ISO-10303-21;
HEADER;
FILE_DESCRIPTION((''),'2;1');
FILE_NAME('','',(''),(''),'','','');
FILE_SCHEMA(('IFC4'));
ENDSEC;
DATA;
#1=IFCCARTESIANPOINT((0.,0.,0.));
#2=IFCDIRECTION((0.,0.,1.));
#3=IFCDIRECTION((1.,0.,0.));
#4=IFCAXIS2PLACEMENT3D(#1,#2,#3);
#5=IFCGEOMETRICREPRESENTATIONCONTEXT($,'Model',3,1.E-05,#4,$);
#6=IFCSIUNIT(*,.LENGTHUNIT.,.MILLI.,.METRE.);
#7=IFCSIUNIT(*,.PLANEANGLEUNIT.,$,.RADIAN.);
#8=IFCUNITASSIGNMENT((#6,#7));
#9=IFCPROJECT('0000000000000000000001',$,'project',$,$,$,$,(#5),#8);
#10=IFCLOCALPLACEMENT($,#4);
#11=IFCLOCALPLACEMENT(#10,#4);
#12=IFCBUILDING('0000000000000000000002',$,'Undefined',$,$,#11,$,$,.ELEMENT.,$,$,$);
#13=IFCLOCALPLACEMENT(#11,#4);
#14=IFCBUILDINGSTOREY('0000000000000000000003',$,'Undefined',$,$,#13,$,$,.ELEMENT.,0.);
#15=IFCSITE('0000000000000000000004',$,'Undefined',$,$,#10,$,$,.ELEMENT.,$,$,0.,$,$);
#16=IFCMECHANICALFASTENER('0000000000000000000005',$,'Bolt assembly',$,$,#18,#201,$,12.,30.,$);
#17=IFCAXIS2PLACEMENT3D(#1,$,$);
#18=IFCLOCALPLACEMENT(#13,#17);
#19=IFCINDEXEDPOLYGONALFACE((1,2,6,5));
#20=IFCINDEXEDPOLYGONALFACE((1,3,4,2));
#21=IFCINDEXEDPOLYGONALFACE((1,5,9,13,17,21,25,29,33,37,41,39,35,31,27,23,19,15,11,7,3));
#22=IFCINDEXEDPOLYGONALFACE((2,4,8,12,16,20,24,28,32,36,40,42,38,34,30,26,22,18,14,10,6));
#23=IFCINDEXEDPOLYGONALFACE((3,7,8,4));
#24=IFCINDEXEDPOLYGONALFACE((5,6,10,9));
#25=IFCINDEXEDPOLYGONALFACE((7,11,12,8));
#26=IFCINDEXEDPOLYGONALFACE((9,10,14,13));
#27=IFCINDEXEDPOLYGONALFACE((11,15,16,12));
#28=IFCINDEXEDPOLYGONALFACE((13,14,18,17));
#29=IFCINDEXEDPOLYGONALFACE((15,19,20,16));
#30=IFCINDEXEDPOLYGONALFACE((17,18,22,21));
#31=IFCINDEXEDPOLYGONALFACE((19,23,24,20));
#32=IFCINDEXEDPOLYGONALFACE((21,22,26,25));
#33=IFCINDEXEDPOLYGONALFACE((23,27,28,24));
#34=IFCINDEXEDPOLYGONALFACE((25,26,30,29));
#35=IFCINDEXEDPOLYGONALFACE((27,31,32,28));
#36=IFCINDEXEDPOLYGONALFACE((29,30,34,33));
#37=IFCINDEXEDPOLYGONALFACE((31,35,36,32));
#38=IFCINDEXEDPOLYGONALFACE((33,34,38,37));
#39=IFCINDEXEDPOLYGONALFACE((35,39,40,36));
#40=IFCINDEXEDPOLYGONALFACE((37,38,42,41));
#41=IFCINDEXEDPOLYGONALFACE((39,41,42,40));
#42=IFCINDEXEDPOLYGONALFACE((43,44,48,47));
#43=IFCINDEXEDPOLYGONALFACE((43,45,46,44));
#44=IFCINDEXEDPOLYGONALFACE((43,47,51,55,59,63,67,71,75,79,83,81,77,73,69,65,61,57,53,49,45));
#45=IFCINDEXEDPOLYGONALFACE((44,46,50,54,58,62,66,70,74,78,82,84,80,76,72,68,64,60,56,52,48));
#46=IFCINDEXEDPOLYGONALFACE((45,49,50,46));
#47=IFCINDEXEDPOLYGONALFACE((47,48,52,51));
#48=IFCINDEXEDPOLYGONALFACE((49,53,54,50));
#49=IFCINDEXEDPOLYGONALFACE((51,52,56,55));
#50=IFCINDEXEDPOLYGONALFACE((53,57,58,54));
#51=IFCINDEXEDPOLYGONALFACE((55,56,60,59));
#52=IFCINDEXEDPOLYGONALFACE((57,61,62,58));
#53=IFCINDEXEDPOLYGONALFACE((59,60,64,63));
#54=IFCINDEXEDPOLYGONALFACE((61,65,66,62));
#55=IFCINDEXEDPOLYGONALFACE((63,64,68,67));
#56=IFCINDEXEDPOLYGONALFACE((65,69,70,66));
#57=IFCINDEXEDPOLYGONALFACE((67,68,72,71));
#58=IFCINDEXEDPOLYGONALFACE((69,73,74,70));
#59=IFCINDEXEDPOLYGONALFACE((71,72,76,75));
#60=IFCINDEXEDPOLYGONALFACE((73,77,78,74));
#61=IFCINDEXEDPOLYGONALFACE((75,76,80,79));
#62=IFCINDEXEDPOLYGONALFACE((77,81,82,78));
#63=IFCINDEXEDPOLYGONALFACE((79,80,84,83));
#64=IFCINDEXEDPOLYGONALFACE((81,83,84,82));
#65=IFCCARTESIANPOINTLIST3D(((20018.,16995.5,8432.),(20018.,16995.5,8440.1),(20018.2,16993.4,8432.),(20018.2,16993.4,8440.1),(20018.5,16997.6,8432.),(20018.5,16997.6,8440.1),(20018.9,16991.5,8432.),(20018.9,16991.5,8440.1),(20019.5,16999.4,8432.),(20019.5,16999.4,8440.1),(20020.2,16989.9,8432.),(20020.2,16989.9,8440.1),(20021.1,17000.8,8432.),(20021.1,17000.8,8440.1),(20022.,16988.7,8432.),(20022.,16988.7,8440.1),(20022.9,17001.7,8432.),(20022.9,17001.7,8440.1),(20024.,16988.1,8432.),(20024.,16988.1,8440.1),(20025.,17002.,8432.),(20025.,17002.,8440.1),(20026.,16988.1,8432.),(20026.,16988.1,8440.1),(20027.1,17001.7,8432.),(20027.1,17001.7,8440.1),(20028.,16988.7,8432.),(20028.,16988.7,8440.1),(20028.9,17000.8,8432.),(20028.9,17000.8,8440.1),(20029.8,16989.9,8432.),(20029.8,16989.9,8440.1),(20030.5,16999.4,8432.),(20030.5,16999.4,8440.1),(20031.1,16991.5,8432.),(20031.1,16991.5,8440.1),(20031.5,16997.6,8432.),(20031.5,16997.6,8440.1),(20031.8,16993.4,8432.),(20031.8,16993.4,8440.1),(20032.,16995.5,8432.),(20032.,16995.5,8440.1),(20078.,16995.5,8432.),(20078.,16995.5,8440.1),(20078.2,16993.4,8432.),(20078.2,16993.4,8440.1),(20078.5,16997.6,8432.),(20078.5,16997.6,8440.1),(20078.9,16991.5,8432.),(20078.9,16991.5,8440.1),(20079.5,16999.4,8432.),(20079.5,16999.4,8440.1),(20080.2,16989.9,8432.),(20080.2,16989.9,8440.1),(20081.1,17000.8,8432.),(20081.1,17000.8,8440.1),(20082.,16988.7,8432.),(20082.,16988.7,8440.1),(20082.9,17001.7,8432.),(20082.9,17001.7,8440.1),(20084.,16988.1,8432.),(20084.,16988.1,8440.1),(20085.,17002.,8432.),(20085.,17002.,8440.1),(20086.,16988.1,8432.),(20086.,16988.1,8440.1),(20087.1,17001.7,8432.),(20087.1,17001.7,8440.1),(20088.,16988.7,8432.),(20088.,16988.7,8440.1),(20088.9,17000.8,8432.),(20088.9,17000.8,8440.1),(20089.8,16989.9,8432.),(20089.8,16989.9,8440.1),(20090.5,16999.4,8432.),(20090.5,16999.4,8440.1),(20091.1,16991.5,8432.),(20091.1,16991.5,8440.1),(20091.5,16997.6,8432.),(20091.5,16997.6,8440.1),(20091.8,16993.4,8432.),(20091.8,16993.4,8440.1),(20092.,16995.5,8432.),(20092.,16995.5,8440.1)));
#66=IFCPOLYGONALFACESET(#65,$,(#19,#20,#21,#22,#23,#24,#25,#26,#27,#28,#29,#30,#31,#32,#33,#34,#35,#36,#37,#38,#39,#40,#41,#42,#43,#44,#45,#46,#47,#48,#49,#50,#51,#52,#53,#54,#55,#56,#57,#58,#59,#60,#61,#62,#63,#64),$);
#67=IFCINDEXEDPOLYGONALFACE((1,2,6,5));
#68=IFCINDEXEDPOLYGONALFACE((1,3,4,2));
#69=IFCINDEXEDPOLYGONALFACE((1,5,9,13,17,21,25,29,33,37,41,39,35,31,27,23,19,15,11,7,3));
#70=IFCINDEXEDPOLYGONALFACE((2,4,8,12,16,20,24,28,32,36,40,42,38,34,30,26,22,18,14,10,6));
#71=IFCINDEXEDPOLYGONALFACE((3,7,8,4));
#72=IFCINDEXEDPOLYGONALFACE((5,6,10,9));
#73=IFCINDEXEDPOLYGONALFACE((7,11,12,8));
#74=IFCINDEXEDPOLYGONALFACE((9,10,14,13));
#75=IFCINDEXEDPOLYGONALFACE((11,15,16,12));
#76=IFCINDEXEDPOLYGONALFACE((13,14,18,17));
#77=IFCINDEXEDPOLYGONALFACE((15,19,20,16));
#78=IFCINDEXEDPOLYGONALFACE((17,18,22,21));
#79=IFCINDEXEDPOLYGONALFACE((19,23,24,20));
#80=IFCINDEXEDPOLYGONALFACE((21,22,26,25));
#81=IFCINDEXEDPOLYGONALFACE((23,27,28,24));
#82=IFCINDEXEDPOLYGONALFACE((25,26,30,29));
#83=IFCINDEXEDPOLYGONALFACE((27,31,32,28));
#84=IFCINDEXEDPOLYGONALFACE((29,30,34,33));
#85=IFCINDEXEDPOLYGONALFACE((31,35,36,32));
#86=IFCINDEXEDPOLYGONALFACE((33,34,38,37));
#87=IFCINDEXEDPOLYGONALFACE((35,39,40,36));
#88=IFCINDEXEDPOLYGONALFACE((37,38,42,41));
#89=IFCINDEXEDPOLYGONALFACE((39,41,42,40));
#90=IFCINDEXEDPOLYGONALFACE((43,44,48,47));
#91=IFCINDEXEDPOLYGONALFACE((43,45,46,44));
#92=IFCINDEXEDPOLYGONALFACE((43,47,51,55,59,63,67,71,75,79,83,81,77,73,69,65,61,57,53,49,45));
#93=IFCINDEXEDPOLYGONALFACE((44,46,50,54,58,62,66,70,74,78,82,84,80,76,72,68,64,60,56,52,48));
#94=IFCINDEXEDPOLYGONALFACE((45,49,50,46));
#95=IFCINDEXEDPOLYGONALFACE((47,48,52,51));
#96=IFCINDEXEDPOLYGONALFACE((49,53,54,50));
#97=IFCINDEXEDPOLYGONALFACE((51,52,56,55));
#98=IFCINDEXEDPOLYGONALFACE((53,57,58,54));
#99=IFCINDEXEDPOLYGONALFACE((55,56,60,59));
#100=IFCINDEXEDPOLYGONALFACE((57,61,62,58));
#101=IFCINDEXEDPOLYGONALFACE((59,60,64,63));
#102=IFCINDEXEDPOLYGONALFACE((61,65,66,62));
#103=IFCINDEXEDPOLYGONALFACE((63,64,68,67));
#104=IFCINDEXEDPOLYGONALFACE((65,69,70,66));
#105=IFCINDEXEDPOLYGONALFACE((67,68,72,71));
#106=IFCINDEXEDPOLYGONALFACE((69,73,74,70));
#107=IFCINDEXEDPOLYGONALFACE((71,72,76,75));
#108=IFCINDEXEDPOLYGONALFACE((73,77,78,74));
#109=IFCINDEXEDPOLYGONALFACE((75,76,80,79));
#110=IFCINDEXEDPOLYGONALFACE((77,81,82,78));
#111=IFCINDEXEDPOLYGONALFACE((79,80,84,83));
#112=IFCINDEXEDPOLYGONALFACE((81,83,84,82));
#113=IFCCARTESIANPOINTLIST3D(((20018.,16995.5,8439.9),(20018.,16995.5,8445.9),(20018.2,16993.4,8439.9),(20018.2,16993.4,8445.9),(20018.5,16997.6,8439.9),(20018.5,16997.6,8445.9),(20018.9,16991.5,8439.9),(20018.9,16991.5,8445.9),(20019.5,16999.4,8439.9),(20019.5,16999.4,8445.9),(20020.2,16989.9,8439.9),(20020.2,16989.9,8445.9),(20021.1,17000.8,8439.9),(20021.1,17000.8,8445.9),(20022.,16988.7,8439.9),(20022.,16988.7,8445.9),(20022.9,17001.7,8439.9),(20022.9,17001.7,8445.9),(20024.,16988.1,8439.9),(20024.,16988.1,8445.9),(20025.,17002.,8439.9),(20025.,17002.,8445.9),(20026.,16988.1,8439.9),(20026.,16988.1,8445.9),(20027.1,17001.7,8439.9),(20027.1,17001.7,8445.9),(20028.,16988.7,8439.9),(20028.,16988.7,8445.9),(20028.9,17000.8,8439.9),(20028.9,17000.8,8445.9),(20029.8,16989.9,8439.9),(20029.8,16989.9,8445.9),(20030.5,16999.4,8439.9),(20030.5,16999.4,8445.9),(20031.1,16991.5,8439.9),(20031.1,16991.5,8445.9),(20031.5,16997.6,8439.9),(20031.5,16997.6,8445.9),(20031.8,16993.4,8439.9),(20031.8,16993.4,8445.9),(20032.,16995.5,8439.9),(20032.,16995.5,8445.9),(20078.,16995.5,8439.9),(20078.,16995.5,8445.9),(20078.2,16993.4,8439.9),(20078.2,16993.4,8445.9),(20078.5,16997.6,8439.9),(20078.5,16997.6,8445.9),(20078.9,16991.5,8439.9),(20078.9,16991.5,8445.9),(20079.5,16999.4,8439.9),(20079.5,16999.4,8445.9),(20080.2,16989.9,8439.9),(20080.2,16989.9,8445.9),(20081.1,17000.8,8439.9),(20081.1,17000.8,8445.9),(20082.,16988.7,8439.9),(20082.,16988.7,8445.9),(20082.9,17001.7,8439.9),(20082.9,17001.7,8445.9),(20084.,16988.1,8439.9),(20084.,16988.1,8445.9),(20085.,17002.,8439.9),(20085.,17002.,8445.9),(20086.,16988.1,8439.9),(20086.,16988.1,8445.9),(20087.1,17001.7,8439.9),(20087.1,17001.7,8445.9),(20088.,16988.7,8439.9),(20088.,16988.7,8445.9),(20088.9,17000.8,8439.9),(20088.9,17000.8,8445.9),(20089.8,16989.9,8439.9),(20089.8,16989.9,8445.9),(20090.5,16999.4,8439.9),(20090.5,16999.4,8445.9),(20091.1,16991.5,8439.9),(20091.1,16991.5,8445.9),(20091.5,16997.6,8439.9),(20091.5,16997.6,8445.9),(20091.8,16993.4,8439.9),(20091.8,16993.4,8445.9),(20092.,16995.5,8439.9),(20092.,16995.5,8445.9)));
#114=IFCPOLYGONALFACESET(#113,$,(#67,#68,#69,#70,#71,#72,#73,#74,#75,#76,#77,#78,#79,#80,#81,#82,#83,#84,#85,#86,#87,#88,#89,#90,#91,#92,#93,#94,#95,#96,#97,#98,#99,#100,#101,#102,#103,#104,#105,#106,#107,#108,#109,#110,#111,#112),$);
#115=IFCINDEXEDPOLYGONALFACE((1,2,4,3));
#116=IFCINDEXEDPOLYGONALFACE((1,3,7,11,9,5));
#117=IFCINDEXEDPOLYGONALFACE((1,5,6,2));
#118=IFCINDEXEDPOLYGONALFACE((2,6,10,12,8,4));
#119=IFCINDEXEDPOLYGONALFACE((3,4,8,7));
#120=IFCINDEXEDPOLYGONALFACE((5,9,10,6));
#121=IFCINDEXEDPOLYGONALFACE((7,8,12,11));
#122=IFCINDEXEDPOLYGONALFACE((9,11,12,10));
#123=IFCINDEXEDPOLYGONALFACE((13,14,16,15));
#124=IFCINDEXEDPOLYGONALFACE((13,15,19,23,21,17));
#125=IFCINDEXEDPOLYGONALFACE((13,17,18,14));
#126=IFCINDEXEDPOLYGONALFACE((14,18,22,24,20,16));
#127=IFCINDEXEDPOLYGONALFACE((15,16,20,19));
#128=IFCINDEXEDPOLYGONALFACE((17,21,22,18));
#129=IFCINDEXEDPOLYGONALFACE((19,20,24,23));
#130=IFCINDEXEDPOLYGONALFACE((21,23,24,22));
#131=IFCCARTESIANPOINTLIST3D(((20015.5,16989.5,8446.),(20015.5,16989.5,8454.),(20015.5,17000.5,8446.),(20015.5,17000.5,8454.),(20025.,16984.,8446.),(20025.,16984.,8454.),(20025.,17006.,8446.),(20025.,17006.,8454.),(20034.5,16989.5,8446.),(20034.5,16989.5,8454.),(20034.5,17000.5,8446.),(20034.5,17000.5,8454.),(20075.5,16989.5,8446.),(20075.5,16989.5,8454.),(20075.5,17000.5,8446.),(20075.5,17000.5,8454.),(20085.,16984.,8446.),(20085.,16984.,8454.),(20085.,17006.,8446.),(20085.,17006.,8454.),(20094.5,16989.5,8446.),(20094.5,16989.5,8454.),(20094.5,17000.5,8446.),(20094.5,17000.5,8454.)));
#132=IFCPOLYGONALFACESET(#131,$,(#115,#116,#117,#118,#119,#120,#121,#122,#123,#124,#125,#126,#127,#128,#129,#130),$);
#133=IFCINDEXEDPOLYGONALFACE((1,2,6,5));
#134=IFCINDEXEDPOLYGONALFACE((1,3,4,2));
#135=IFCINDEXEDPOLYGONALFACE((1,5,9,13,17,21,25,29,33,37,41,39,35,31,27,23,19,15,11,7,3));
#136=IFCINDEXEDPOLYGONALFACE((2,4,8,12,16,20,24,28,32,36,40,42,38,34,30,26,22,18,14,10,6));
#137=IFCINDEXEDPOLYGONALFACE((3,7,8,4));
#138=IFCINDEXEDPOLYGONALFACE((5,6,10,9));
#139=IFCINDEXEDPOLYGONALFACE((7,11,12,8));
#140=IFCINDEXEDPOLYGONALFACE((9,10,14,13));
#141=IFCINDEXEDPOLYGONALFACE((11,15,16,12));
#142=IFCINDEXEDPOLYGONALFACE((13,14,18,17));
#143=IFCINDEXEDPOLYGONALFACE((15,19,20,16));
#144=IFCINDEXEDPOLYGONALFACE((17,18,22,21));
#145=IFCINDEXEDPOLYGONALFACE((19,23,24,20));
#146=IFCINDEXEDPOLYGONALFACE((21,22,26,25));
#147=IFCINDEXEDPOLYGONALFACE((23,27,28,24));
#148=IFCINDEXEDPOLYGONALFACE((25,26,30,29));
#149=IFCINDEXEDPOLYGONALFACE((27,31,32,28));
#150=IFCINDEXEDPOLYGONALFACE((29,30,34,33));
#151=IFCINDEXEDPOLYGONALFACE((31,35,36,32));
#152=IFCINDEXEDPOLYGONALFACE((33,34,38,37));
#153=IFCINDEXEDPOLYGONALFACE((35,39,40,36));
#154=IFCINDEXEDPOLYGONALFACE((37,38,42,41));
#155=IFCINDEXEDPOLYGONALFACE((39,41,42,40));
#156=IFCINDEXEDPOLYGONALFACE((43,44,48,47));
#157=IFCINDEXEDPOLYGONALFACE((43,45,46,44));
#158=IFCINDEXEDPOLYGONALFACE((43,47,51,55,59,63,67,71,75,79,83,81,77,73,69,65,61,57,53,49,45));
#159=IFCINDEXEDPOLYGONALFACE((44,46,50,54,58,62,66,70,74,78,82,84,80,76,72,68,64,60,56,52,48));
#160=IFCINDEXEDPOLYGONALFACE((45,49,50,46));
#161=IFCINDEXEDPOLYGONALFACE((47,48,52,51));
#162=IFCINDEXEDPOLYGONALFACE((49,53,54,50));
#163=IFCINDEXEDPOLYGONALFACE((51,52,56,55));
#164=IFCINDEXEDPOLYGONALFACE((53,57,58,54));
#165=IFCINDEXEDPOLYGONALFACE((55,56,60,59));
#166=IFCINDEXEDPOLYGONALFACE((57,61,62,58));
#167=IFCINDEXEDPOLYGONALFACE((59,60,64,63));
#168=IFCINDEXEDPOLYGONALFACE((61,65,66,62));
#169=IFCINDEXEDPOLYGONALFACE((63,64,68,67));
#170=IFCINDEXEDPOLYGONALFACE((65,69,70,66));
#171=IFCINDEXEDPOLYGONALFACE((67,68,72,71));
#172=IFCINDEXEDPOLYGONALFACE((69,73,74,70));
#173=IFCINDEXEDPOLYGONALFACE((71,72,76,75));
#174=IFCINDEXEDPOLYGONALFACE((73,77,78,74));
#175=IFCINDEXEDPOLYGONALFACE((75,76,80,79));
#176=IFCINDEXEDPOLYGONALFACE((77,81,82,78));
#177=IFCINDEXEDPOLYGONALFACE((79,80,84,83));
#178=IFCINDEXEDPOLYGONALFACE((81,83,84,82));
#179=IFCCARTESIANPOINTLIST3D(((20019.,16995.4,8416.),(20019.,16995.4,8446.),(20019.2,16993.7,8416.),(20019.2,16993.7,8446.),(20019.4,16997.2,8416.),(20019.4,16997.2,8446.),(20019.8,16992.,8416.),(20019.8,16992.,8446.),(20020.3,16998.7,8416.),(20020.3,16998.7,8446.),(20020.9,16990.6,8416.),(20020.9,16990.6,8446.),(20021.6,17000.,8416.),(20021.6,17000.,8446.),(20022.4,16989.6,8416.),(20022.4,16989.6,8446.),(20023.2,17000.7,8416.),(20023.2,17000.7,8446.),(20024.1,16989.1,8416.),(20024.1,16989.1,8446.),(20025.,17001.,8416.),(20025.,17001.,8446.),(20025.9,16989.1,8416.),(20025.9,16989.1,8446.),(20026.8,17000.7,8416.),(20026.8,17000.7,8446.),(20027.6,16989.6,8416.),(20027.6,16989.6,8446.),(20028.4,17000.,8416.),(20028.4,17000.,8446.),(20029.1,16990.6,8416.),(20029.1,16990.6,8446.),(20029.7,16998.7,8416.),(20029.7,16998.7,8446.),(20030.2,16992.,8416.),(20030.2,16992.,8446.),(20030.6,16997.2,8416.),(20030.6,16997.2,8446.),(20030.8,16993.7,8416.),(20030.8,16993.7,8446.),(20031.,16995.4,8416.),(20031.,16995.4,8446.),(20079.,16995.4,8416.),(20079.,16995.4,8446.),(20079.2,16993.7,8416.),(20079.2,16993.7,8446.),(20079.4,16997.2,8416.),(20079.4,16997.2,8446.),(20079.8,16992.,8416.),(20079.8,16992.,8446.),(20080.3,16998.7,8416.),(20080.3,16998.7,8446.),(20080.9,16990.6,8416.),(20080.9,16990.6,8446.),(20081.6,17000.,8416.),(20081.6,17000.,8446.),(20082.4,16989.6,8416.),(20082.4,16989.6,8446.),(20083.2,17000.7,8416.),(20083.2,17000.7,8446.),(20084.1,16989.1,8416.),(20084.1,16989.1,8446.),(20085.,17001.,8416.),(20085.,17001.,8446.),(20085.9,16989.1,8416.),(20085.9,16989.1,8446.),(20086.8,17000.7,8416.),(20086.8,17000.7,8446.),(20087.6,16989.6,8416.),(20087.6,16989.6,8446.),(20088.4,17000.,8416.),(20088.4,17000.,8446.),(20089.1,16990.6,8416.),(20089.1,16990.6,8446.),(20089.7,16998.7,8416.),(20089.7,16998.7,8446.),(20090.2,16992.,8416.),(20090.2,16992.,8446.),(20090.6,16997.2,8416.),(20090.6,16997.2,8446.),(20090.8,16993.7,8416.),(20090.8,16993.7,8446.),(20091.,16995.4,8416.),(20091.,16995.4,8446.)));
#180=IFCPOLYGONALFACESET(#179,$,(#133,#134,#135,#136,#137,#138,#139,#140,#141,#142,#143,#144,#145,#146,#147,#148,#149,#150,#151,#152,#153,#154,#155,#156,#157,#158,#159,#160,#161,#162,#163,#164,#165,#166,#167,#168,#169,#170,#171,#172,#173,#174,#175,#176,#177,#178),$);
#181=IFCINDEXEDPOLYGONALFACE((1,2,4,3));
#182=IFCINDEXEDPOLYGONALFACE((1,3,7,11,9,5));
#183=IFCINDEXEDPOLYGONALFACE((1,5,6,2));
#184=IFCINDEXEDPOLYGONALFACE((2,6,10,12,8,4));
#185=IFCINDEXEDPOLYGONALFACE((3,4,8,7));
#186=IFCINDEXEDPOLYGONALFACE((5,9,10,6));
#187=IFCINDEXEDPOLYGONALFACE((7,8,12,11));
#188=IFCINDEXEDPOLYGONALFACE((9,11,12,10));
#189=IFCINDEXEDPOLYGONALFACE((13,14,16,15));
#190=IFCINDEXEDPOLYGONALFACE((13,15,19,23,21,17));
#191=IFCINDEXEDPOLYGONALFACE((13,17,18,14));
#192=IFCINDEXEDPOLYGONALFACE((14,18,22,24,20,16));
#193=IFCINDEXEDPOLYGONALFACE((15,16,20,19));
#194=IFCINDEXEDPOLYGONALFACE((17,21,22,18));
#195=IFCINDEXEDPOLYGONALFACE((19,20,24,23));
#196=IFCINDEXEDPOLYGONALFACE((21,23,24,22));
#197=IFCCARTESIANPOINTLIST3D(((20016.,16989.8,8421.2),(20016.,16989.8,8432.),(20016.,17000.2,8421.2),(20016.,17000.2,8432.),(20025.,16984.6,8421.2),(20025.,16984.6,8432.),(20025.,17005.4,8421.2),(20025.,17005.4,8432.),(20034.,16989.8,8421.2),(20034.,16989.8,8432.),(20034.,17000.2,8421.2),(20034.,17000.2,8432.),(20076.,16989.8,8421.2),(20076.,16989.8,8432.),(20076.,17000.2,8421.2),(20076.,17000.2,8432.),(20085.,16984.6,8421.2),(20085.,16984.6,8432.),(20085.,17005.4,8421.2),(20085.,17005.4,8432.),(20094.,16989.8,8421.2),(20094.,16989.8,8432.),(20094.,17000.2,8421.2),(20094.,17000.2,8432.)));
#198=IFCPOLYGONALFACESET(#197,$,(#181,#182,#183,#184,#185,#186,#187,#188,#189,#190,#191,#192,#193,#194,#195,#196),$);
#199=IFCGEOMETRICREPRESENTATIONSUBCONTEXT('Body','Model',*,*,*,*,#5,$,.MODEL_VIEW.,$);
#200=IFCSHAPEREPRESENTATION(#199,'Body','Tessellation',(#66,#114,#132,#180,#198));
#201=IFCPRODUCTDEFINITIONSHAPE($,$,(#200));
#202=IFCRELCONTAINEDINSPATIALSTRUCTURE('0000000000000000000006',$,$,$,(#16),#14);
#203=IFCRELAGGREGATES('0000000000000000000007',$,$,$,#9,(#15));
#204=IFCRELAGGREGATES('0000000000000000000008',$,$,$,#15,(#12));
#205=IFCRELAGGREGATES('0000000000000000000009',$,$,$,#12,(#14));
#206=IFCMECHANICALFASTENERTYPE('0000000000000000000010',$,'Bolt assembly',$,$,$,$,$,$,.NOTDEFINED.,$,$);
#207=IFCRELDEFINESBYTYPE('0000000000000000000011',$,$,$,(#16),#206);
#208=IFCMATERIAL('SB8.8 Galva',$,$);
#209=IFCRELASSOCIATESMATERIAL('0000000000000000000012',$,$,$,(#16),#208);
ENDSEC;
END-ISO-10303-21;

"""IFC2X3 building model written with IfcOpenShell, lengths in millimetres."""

from ifc_helpers import new_model, si_unit, frame, origin_with_axes, origin_2d_with_axis, place, context, subcontext, project, spatial, polyline, circle, outline, extrude, source, transform, mapped, material, type_object, element, save


model = new_model("IFC2X3")

# Units and contexts
model_context = context("Model", 3, precision=1e-05, world=origin_with_axes())
body_context = subcontext(model_context, "Body", "Model", "MODEL_VIEW")
ifc_project = project(units=[si_unit("LENGTHUNIT", "METRE", prefix="MILLI"), si_unit("PLANEANGLEUNIT", "RADIAN")], contexts=[model_context])

# Site, building, storey
site_placement = place(None, origin_with_axes())
site = spatial("IfcSite", under=ifc_project, at=site_placement, Name="Undefined", CompositionType="ELEMENT", RefElevation=0.0)
building_placement = place(site_placement, origin_with_axes())
building = spatial("IfcBuilding", under=site, at=building_placement, Name="Undefined", CompositionType="ELEMENT")
storey_placement = place(building_placement, origin_with_axes())
storey = spatial("IfcBuildingStorey", under=building, at=storey_placement, Name="Undefined", CompositionType="ELEMENT", Elevation=0.0)

# Mechanical fastener
mechanical_fastener_type = type_object("IfcMechanicalFastenerType", Name="Bolt assembly")
ifc_material_1 = material(Name="SB8.8 Galva")
shared_shape_1 = source(origin_with_axes(), body_context, "Body", "SweptSolid", [
    extrude(circle(Radius=7.0, at=origin_2d_with_axis()), frame((0.0, -0.1, 0.0), z_axis=(0.0, 1.0, 0.0), x_axis=(1.0, 0.0, 0.0)), (0.0, 0.0, 1.0), 8.1),
    extrude(circle(Radius=7.0, at=origin_2d_with_axis()), frame((0.0, -5.9, 0.0), z_axis=(0.0, 1.0, 0.0), x_axis=(1.0, 0.0, 0.0)), (0.0, 0.0, 1.0), 6.0),
    extrude(outline(polyline([(11.0, 0.0), (5.5, 9.5), (-5.5, 9.5), (-11.0, 0.0), (-5.5, -9.5), (5.5, -9.5), (11.0, 0.0)])), frame((0.0, -14.0, 0.0), z_axis=(0.0, 1.0, 0.0), x_axis=(1.0, 0.0, 0.0)), (0.0, 0.0, 1.0), 8.0),
    extrude(circle(Radius=6.0, at=origin_2d_with_axis()), frame((0.0, -6.0, 0.0), z_axis=(0.0, 1.0, 0.0), x_axis=(1.0, 0.0, 0.0)), (0.0, 0.0, 1.0), 30.0),
    extrude(outline(polyline([(10.4, 0.0), (5.2, 9.0), (-5.2, 9.0), (-10.4, 0.0), (-5.2, -9.0), (5.2, -9.0), (10.4, 0.0)])), frame((0.0, 8.0, 0.0), z_axis=(0.0, 1.0, 0.0), x_axis=(1.0, 0.0, 0.0)), (0.0, 0.0, 1.0), 10.8),
])
for number, where, z_axis, x_axis, name in (
    (1, (20055.0, 16995.0, 8440.0), (-1.0, 0.0, 0.0), (0.0, 1.0, 0.0), "Bolt assembly"),
):
    element("IfcMechanicalFastener", number, at=place(storey_placement, frame(where, z_axis=z_axis, x_axis=x_axis)), inside=storey, type_object=mechanical_fastener_type, material=ifc_material_1, Name=name, NominalDiameter=12.0, NominalLength=30.0, context=body_context, shape_type="MappedRepresentation", body=[
        mapped(shared_shape_1, transform((0.0, 0.0, -30.0))),
        mapped(shared_shape_1, transform((0.0, 0.0, 30.0))),
    ])

save(model, "model.ifc")
